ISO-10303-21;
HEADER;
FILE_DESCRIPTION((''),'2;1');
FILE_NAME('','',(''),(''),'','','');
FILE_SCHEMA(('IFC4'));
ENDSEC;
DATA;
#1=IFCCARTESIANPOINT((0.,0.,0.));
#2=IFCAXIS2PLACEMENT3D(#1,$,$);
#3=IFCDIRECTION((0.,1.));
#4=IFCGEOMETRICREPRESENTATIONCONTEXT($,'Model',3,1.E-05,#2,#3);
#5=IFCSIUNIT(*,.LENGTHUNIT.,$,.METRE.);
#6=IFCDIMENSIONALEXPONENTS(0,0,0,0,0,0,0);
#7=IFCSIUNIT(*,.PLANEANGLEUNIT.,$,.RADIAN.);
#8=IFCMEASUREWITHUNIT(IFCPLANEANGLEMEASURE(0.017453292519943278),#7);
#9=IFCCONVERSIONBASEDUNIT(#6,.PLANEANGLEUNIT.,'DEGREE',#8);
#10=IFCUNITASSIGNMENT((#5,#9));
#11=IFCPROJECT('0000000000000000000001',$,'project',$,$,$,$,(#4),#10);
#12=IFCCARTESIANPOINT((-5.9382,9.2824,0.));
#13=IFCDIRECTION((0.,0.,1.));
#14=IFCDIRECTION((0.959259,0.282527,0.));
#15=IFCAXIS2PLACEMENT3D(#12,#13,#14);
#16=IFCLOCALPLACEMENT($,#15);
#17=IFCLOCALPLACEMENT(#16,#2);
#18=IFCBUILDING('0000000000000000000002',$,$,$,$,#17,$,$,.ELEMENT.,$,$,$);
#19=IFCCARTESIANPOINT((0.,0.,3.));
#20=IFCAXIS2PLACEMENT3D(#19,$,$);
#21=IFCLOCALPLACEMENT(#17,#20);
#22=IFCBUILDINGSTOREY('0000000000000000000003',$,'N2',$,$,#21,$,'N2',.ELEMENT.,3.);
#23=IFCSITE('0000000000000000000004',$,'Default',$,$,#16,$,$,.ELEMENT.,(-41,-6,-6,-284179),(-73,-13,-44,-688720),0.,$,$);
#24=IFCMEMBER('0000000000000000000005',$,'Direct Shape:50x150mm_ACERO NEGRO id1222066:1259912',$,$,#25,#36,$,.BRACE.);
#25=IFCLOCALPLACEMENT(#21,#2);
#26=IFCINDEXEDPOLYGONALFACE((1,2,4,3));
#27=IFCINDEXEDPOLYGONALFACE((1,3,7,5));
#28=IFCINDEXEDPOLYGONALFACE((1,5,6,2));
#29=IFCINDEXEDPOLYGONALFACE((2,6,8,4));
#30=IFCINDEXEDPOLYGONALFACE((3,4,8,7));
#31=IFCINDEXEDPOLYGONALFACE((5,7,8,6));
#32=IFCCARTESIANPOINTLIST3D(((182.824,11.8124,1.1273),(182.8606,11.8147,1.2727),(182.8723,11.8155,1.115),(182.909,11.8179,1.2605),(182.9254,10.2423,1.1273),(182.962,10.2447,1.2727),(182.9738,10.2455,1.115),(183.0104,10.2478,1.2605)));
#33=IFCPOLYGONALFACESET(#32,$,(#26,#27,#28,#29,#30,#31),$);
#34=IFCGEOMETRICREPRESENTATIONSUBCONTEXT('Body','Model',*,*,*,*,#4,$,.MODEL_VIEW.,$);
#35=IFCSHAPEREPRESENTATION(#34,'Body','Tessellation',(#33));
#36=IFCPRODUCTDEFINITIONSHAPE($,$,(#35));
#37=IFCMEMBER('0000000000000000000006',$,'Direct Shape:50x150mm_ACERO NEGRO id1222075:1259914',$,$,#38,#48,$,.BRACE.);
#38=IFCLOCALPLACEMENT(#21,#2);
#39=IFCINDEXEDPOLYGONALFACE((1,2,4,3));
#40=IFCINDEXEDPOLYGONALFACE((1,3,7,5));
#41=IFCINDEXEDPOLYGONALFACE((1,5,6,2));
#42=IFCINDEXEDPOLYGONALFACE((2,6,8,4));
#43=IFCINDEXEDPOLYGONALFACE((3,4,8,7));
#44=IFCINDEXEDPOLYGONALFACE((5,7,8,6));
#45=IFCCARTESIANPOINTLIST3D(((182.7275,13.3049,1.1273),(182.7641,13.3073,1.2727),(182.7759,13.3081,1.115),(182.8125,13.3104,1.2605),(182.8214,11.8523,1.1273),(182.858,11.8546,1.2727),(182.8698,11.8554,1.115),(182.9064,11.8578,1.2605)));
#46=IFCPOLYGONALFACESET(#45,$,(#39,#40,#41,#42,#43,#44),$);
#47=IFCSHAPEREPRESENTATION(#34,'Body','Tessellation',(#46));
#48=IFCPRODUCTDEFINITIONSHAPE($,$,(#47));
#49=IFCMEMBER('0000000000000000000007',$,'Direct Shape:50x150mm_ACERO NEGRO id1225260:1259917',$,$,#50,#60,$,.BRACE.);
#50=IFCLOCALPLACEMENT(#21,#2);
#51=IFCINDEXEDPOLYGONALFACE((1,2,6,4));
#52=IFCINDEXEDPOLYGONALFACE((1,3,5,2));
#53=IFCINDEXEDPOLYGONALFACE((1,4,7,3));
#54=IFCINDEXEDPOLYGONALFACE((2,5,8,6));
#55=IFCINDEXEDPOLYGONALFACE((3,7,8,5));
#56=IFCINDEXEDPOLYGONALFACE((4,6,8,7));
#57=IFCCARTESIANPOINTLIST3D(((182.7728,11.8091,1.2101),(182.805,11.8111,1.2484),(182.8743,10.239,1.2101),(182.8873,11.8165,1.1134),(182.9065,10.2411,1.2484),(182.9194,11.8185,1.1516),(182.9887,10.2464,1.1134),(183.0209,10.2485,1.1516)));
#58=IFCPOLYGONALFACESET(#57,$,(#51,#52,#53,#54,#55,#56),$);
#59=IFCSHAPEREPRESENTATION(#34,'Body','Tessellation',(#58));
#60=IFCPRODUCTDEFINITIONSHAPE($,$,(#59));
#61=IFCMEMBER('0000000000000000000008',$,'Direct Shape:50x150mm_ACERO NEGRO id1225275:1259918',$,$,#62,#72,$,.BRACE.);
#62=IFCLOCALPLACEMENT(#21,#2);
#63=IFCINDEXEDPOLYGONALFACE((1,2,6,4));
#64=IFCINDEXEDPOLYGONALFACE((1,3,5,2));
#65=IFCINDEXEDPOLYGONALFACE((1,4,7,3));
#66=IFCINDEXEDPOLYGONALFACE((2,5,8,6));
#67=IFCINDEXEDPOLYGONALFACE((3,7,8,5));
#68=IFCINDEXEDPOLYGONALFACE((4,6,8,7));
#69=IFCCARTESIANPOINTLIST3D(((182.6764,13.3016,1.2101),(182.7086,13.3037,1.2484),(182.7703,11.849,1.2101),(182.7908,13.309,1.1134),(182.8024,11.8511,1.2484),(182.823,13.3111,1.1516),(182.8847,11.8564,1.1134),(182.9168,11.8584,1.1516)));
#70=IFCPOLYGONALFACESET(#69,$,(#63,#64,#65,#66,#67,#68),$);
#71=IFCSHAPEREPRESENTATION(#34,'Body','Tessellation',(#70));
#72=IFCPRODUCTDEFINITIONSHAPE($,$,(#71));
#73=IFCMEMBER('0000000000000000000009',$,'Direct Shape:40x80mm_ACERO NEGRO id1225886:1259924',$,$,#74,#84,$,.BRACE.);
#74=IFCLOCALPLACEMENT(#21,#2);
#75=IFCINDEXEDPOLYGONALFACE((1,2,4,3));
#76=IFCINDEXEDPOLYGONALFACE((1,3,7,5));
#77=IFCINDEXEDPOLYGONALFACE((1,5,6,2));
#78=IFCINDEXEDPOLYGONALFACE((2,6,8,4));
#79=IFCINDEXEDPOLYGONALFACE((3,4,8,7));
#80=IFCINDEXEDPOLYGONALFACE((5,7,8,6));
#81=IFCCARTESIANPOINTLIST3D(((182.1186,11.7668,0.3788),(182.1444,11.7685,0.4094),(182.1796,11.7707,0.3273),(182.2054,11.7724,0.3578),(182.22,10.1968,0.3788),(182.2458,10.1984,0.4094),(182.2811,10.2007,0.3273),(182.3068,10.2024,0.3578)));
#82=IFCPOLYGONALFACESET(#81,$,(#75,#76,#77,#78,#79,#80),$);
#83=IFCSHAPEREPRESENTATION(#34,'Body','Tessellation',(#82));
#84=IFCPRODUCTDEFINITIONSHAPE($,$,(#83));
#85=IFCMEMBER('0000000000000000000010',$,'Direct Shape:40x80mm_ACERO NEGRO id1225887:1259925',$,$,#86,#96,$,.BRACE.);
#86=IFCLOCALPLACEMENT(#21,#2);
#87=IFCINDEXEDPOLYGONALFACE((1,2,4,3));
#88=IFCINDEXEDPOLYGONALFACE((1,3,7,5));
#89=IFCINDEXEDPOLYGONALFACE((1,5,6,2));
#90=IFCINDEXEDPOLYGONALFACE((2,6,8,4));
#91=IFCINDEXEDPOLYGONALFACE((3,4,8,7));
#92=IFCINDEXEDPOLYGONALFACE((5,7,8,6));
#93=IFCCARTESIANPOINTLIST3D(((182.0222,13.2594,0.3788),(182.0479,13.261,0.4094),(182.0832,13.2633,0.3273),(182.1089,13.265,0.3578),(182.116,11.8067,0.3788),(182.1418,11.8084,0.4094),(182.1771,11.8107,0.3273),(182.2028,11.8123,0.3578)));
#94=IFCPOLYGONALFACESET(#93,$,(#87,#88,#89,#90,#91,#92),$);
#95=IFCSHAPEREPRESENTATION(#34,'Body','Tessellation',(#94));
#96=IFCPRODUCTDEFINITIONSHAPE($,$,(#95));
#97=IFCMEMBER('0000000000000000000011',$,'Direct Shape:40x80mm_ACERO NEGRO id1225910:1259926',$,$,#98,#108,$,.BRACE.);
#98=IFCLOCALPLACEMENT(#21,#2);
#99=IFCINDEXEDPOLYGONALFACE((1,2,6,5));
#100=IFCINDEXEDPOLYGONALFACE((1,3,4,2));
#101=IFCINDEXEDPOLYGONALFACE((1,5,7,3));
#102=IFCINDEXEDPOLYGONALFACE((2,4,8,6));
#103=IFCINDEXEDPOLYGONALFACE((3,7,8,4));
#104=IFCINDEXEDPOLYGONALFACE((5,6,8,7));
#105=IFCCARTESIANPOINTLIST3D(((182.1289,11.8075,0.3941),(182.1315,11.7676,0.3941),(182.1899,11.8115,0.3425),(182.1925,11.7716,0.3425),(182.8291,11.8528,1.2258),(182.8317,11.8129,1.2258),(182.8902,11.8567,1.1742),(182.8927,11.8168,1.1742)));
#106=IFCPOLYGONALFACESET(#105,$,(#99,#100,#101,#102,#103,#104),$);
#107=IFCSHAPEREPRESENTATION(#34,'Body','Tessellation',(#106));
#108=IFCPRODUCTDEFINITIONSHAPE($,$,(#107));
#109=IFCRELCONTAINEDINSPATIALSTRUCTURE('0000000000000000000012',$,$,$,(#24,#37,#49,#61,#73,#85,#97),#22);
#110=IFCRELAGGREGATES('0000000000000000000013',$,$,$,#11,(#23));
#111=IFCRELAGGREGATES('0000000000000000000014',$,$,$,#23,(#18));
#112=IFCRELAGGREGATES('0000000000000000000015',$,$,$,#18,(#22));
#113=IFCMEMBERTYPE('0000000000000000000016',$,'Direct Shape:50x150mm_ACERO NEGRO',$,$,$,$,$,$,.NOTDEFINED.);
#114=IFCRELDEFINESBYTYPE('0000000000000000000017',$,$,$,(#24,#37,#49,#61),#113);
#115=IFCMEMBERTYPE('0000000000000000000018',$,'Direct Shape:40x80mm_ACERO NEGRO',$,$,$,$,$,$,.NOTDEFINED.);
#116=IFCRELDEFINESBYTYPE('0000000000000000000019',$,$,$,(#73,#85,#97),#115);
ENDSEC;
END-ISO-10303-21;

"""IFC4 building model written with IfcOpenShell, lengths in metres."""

from ifc_helpers import new_model, entity, si_unit, converted_unit, direction, frame, frame_2d, origin, place, context, subcontext, project, spatial, rectangle, extrude, type_object, element, save


model = new_model("IFC4")

# Units and contexts
model_context = context("Model", 3, precision=1e-05, world=origin(), true_north=direction((0.0, 1.0)))
body_context = subcontext(model_context, "Body", "Model", "MODEL_VIEW")
ifc_project = project(units=[si_unit("LENGTHUNIT", "METRE"), converted_unit("PLANEANGLEUNIT", "DEGREE", entity("IfcPlaneAngleMeasure", 0.017453292519943278), si_unit("PLANEANGLEUNIT", "RADIAN"), dimensions=[0, 0, 0, 0, 0, 0, 0])], contexts=[model_context])

# Site, building, storey
site_placement = place(None, frame((-5.9382, 9.2824, 0.0), z_axis=(0.0, 0.0, 1.0), x_axis=(0.959259, 0.282527, 0.0)))
site = spatial("IfcSite", under=ifc_project, at=site_placement, Name="Default", CompositionType="ELEMENT", RefLatitude=(-41, -6, -6, -284179), RefLongitude=(-73, -13, -44, -688720), RefElevation=0.0)
building_placement = place(site_placement, origin())
building = spatial("IfcBuilding", under=site, at=building_placement, CompositionType="ELEMENT")
storey_placement = place(building_placement, frame((0.0, 0.0, 3.0)))
storey = spatial("IfcBuildingStorey", under=building, at=storey_placement, Name="N2", LongName="N2", CompositionType="ELEMENT", Elevation=3.0)

# Members
member_type_1 = type_object("IfcMemberType", Name="Direct Shape:50x150mm_ACERO NEGRO", PredefinedType="NOTDEFINED")
member_1_placement = place(storey_placement, origin())
element("IfcMember", 1, at=member_1_placement, inside=storey, type_object=member_type_1, Name="Direct Shape:50x150mm_ACERO NEGRO id1222066:1259912", PredefinedType="BRACE", context=body_context, shape_type="SweptSolid", body=[
    extrude(rectangle(XDim=0.15, YDim=0.05, at=frame_2d((0.0, 0.0), x_axis=(1.0, 0.0))), frame((182.9679, 10.2451, 1.1939), z_axis=(-0.064471, 0.99792, 0.0), x_axis=(-0.24414, -0.015773, -0.969612)), (0.0, 0.0, 1.0), 1.5733),
])
member_2_placement = place(storey_placement, origin())
element("IfcMember", 2, at=member_2_placement, inside=storey, type_object=member_type_1, Name="Direct Shape:50x150mm_ACERO NEGRO id1222075:1259914", PredefinedType="BRACE", context=body_context, shape_type="SweptSolid", body=[
    extrude(rectangle(XDim=0.15, YDim=0.05, at=frame_2d((0.0, 0.0), x_axis=(0.0, 1.0))), frame((182.8639, 11.855, 1.1939), z_axis=(-0.064471, 0.99792, 0.0), x_axis=(0.967595, 0.062512, -0.244649)), (0.0, 0.0, 1.0), 1.4557),
])
member_3_placement = place(storey_placement, origin())
element("IfcMember", 3, at=member_3_placement, inside=storey, type_object=member_type_1, Name="Direct Shape:50x150mm_ACERO NEGRO id1225260:1259917", PredefinedType="BRACE", context=body_context, shape_type="SweptSolid", body=[
    extrude(rectangle(XDim=0.05, YDim=0.15, at=frame_2d((0.0, 0.0), x_axis=(0.0, 1.0))), frame((182.9476, 10.2438, 1.1809), z_axis=(-0.064471, 0.99792, 0.0), x_axis=(0.762714, 0.049276, -0.644857)), (0.0, 0.0, 1.0), 1.5733),
])
member_4_placement = place(storey_placement, origin())
element("IfcMember", 4, at=member_4_placement, inside=storey, type_object=member_type_1, Name="Direct Shape:50x150mm_ACERO NEGRO id1225275:1259918", PredefinedType="BRACE", context=body_context, shape_type="SweptSolid", body=[
    extrude(rectangle(XDim=0.05, YDim=0.15, at=frame_2d((0.0, 0.0), x_axis=(0.0, 1.0))), frame((182.8436, 11.8537, 1.1809), z_axis=(-0.064471, 0.99792, 0.0), x_axis=(0.762714, 0.049276, -0.644857)), (0.0, 0.0, 1.0), 1.4557),
])
member_type_2 = type_object("IfcMemberType", Name="Direct Shape:40x80mm_ACERO NEGRO", PredefinedType="NOTDEFINED")
member_5_placement = place(storey_placement, origin())
element("IfcMember", 5, at=member_5_placement, inside=storey, type_object=member_type_2, Name="Direct Shape:40x80mm_ACERO NEGRO id1225886:1259924", PredefinedType="BRACE", context=body_context, shape_type="SweptSolid", body=[
    extrude(rectangle(XDim=0.04, YDim=0.08, at=frame_2d((0.0, 0.0), x_axis=(0.0, 1.0))), frame((182.2634, 10.1996, 0.3683), z_axis=(-0.064471, 0.99792, 0.0), x_axis=(0.762714, 0.049276, -0.644857)), (0.0, 0.0, 1.0), 1.5733),
])
member_6_placement = place(storey_placement, origin())
element("IfcMember", 6, at=member_6_placement, inside=storey, type_object=member_type_2, Name="Direct Shape:40x80mm_ACERO NEGRO id1225887:1259925", PredefinedType="BRACE", context=body_context, shape_type="SweptSolid", body=[
    extrude(rectangle(XDim=0.04, YDim=0.08, at=frame_2d((0.0, 0.0), x_axis=(0.0, 1.0))), frame((182.1594, 11.8095, 0.3683), z_axis=(-0.064471, 0.99792, 0.0), x_axis=(0.762714, 0.049276, -0.644857)), (0.0, 0.0, 1.0), 1.4557),
])
member_7_placement = place(storey_placement, origin())
element("IfcMember", 7, at=member_7_placement, inside=storey, type_object=member_type_2, Name="Direct Shape:40x80mm_ACERO NEGRO id1225910:1259926", PredefinedType="BRACE", context=body_context, shape_type="SweptSolid", body=[
    extrude(rectangle(XDim=0.08, YDim=0.04, at=frame_2d((0.0, 0.0), x_axis=(0.0, 1.0))), frame((182.1607, 11.7896, 0.3683), z_axis=(0.643515, 0.041575, 0.764304), x_axis=(0.064471, -0.99792, 0.0)), (0.0, 0.0, 1.0), 1.0881),
])

save(model, "model.ifc")
